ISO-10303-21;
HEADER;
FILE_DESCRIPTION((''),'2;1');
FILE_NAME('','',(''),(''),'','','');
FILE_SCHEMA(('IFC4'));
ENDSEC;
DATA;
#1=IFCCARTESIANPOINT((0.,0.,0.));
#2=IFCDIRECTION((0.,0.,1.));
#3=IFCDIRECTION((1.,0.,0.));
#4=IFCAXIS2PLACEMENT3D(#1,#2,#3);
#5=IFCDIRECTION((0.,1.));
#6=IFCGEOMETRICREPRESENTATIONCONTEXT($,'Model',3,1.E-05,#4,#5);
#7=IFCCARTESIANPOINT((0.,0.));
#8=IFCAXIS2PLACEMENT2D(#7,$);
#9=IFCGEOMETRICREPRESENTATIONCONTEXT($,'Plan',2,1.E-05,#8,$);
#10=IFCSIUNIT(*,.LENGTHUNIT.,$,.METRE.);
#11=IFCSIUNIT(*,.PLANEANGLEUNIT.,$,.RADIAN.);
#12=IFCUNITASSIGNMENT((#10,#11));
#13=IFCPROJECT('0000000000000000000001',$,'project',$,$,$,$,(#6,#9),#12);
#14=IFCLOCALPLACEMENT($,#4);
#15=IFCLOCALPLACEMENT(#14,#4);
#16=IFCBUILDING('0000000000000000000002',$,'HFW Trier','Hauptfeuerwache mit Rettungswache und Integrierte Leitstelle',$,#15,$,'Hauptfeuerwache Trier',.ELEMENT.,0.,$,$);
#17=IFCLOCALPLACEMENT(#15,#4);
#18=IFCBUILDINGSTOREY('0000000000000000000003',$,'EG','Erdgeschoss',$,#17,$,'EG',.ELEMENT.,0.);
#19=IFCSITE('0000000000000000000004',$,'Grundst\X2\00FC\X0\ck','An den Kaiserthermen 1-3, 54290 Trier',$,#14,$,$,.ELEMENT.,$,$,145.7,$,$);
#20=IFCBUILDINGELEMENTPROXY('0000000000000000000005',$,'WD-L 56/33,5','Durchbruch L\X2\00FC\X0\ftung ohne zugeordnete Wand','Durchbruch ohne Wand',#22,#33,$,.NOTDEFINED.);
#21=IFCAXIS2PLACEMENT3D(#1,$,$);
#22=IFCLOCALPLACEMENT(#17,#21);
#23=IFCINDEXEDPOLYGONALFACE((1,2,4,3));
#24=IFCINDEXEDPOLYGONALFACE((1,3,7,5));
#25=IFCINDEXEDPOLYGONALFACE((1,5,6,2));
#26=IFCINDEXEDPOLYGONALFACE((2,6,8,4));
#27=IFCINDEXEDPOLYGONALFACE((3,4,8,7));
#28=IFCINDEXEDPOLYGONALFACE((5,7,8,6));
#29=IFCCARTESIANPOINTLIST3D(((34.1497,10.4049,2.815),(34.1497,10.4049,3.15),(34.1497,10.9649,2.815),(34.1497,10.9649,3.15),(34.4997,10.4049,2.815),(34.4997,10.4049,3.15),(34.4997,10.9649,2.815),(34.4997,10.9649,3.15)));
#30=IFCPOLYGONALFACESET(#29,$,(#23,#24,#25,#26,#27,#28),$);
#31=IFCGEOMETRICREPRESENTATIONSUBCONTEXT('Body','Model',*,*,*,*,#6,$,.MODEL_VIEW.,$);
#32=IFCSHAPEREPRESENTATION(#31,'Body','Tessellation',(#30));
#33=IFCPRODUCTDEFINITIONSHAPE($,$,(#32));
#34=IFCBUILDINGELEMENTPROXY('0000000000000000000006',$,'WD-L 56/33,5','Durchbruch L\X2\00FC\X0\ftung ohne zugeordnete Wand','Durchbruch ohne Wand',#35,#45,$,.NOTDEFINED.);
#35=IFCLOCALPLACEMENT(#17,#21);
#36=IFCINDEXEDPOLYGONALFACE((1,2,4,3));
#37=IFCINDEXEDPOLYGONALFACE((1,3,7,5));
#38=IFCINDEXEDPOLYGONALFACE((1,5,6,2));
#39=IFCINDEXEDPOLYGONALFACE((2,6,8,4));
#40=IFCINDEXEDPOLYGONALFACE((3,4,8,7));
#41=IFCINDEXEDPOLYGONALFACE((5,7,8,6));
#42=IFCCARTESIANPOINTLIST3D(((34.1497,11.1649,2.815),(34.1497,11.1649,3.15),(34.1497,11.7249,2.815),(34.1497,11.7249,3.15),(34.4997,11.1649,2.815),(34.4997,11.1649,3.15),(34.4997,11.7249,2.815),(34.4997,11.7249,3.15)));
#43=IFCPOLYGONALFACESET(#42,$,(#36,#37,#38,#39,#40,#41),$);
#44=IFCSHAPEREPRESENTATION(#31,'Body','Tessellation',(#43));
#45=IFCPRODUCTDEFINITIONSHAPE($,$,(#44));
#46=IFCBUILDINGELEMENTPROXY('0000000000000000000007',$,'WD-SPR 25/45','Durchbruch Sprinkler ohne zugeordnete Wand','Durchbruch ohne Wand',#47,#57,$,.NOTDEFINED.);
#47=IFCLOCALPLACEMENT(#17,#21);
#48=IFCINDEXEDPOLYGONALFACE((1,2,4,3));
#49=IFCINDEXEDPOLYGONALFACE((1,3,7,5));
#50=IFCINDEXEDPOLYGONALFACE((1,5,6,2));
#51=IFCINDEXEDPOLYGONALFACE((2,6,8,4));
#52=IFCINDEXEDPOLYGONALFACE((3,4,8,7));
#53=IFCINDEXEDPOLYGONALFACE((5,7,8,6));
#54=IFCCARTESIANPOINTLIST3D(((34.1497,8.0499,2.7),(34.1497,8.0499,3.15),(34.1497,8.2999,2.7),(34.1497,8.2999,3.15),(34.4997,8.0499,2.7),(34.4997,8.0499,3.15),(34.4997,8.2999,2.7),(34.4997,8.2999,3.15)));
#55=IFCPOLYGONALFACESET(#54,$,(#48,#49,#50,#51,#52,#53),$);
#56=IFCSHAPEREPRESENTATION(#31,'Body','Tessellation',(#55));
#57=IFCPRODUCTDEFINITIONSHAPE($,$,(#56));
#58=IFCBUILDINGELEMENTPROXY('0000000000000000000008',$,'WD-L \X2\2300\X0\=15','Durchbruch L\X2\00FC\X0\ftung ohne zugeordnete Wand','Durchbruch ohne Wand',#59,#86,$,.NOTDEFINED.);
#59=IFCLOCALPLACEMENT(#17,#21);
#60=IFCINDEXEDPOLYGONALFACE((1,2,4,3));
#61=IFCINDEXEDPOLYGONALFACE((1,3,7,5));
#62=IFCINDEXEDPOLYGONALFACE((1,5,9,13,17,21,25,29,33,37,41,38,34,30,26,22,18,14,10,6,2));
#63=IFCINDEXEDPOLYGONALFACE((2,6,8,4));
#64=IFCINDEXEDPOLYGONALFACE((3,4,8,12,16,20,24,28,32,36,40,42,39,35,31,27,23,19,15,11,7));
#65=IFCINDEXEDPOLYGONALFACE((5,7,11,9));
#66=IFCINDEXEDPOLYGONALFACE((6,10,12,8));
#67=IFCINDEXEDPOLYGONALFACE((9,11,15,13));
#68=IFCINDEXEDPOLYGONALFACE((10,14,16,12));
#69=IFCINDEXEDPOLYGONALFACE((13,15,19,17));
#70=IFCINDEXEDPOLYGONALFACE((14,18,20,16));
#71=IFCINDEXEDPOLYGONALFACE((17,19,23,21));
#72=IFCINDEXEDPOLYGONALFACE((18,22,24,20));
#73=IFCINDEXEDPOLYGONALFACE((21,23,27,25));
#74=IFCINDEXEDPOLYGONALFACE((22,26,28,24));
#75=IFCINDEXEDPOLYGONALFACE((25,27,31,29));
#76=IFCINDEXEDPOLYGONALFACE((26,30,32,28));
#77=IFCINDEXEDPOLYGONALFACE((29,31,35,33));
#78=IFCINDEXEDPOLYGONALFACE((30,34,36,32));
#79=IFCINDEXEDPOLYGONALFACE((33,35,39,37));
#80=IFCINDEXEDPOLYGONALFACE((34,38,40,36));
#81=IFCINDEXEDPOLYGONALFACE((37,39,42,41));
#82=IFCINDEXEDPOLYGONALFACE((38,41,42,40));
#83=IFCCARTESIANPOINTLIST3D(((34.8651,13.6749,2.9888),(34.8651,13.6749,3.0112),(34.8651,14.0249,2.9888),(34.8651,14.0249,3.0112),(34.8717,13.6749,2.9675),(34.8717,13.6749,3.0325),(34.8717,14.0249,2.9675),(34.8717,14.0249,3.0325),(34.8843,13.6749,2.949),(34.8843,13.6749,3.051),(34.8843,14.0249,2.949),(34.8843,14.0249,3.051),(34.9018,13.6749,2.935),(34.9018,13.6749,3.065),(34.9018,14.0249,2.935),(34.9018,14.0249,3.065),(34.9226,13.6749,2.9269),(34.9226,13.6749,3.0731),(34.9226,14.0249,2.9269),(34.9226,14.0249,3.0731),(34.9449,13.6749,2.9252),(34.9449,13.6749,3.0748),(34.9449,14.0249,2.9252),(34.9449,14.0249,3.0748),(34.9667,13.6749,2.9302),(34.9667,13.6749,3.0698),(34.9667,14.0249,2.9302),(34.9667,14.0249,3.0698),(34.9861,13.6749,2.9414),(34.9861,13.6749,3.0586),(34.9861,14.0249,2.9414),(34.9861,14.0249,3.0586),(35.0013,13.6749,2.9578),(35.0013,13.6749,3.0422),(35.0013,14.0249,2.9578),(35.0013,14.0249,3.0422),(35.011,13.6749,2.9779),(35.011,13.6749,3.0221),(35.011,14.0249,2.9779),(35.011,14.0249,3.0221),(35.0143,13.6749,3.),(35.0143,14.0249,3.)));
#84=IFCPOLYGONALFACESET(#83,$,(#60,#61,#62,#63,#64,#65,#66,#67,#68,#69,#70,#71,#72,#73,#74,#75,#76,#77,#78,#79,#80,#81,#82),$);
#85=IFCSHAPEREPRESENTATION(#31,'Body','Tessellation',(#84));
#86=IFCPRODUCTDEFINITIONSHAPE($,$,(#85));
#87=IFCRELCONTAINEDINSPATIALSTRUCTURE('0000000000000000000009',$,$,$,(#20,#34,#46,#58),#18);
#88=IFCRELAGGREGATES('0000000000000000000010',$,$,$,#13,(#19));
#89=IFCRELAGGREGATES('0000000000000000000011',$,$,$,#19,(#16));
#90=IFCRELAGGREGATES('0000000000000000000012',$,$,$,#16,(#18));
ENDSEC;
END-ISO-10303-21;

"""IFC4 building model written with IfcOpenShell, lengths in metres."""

from ifc_helpers import new_model, si_unit, direction, frame, origin_with_axes, origin_2d, place, context, subcontext, project, spatial, rectangle, circle, extrude, element, save


model = new_model("IFC4")

# Units and contexts
model_context = context("Model", 3, precision=1e-05, world=origin_with_axes(), true_north=direction((0.0, 1.0)))
plan_context = context("Plan", 2, precision=1e-05, world=origin_2d())
body_context = subcontext(model_context, "Body", "Model", "MODEL_VIEW")
ifc_project = project(units=[si_unit("LENGTHUNIT", "METRE"), si_unit("PLANEANGLEUNIT", "RADIAN")], contexts=[model_context, plan_context])

# Site, building, storey
site_placement = place(None, origin_with_axes())
site = spatial("IfcSite", under=ifc_project, at=site_placement, Name="Grundstück", Description="An den Kaiserthermen 1-3, 54290 Trier", CompositionType="ELEMENT", RefElevation=145.7)
building_placement = place(site_placement, origin_with_axes())
building = spatial("IfcBuilding", under=site, at=building_placement, Name="HFW Trier", Description="Hauptfeuerwache mit Rettungswache und Integrierte Leitstelle", LongName="Hauptfeuerwache Trier", CompositionType="ELEMENT", ElevationOfRefHeight=0.0)
storey_placement = place(building_placement, origin_with_axes())
storey = spatial("IfcBuildingStorey", under=building, at=storey_placement, Name="EG", Description="Erdgeschoss", LongName="EG", CompositionType="ELEMENT", Elevation=0.0)

# Building element proxies
for number, where, z_axis, x_axis, name in (
    (1, (34.3247, 10.6849, 2.815), (0.0, 0.0, 1.0), (0.0, 1.0, 0.0), "WD-L 56/33,5"),
    (2, (34.3247, 11.4449, 2.815), (0.0, 0.0, 1.0), (0.0, 1.0, 0.0), "WD-L 56/33,5"),
):
    element("IfcBuildingElementProxy", number, at=place(storey_placement, frame(where, z_axis=z_axis, x_axis=x_axis)), inside=storey, Name=name, Description="Durchbruch Lüftung ohne zugeordnete Wand", ObjectType="Durchbruch ohne Wand", PredefinedType="NOTDEFINED", context=body_context, shape_type="SweptSolid", body=[
        extrude(rectangle(XDim=0.56, YDim=0.35, at=origin_2d()), origin_with_axes(), (0.0, 0.0, 1.0), 0.335),
    ])
proxy_1_placement = place(storey_placement, frame((34.3247, 8.1749, 2.7), z_axis=(0.0, 0.0, 1.0), x_axis=(0.0, 1.0, 0.0)))
element("IfcBuildingElementProxy", 3, at=proxy_1_placement, inside=storey, Name="WD-SPR 25/45", Description="Durchbruch Sprinkler ohne zugeordnete Wand", ObjectType="Durchbruch ohne Wand", PredefinedType="NOTDEFINED", context=body_context, shape_type="SweptSolid", body=[
    extrude(rectangle(XDim=0.25, YDim=0.35, at=origin_2d()), origin_with_axes(), (0.0, 0.0, 1.0), 0.45),
])
proxy_2_placement = place(storey_placement, frame((34.9393, 13.8499, 2.925), z_axis=(0.0, 0.0, 1.0), x_axis=(1.0, 0.0, 0.0)))
element("IfcBuildingElementProxy", 4, at=proxy_2_placement, inside=storey, Name="WD-L ⌀=15", Description="Durchbruch Lüftung ohne zugeordnete Wand", ObjectType="Durchbruch ohne Wand", PredefinedType="NOTDEFINED", context=body_context, shape_type="SweptSolid", body=[
    extrude(circle(Radius=0.075, at=origin_2d()), frame((0.0, -0.175, 0.075), z_axis=(0.0, 1.0, 0.0), x_axis=(1.0, 0.0, 0.0)), (0.0, 0.0, 1.0), 0.35),
])

save(model, "model.ifc")
